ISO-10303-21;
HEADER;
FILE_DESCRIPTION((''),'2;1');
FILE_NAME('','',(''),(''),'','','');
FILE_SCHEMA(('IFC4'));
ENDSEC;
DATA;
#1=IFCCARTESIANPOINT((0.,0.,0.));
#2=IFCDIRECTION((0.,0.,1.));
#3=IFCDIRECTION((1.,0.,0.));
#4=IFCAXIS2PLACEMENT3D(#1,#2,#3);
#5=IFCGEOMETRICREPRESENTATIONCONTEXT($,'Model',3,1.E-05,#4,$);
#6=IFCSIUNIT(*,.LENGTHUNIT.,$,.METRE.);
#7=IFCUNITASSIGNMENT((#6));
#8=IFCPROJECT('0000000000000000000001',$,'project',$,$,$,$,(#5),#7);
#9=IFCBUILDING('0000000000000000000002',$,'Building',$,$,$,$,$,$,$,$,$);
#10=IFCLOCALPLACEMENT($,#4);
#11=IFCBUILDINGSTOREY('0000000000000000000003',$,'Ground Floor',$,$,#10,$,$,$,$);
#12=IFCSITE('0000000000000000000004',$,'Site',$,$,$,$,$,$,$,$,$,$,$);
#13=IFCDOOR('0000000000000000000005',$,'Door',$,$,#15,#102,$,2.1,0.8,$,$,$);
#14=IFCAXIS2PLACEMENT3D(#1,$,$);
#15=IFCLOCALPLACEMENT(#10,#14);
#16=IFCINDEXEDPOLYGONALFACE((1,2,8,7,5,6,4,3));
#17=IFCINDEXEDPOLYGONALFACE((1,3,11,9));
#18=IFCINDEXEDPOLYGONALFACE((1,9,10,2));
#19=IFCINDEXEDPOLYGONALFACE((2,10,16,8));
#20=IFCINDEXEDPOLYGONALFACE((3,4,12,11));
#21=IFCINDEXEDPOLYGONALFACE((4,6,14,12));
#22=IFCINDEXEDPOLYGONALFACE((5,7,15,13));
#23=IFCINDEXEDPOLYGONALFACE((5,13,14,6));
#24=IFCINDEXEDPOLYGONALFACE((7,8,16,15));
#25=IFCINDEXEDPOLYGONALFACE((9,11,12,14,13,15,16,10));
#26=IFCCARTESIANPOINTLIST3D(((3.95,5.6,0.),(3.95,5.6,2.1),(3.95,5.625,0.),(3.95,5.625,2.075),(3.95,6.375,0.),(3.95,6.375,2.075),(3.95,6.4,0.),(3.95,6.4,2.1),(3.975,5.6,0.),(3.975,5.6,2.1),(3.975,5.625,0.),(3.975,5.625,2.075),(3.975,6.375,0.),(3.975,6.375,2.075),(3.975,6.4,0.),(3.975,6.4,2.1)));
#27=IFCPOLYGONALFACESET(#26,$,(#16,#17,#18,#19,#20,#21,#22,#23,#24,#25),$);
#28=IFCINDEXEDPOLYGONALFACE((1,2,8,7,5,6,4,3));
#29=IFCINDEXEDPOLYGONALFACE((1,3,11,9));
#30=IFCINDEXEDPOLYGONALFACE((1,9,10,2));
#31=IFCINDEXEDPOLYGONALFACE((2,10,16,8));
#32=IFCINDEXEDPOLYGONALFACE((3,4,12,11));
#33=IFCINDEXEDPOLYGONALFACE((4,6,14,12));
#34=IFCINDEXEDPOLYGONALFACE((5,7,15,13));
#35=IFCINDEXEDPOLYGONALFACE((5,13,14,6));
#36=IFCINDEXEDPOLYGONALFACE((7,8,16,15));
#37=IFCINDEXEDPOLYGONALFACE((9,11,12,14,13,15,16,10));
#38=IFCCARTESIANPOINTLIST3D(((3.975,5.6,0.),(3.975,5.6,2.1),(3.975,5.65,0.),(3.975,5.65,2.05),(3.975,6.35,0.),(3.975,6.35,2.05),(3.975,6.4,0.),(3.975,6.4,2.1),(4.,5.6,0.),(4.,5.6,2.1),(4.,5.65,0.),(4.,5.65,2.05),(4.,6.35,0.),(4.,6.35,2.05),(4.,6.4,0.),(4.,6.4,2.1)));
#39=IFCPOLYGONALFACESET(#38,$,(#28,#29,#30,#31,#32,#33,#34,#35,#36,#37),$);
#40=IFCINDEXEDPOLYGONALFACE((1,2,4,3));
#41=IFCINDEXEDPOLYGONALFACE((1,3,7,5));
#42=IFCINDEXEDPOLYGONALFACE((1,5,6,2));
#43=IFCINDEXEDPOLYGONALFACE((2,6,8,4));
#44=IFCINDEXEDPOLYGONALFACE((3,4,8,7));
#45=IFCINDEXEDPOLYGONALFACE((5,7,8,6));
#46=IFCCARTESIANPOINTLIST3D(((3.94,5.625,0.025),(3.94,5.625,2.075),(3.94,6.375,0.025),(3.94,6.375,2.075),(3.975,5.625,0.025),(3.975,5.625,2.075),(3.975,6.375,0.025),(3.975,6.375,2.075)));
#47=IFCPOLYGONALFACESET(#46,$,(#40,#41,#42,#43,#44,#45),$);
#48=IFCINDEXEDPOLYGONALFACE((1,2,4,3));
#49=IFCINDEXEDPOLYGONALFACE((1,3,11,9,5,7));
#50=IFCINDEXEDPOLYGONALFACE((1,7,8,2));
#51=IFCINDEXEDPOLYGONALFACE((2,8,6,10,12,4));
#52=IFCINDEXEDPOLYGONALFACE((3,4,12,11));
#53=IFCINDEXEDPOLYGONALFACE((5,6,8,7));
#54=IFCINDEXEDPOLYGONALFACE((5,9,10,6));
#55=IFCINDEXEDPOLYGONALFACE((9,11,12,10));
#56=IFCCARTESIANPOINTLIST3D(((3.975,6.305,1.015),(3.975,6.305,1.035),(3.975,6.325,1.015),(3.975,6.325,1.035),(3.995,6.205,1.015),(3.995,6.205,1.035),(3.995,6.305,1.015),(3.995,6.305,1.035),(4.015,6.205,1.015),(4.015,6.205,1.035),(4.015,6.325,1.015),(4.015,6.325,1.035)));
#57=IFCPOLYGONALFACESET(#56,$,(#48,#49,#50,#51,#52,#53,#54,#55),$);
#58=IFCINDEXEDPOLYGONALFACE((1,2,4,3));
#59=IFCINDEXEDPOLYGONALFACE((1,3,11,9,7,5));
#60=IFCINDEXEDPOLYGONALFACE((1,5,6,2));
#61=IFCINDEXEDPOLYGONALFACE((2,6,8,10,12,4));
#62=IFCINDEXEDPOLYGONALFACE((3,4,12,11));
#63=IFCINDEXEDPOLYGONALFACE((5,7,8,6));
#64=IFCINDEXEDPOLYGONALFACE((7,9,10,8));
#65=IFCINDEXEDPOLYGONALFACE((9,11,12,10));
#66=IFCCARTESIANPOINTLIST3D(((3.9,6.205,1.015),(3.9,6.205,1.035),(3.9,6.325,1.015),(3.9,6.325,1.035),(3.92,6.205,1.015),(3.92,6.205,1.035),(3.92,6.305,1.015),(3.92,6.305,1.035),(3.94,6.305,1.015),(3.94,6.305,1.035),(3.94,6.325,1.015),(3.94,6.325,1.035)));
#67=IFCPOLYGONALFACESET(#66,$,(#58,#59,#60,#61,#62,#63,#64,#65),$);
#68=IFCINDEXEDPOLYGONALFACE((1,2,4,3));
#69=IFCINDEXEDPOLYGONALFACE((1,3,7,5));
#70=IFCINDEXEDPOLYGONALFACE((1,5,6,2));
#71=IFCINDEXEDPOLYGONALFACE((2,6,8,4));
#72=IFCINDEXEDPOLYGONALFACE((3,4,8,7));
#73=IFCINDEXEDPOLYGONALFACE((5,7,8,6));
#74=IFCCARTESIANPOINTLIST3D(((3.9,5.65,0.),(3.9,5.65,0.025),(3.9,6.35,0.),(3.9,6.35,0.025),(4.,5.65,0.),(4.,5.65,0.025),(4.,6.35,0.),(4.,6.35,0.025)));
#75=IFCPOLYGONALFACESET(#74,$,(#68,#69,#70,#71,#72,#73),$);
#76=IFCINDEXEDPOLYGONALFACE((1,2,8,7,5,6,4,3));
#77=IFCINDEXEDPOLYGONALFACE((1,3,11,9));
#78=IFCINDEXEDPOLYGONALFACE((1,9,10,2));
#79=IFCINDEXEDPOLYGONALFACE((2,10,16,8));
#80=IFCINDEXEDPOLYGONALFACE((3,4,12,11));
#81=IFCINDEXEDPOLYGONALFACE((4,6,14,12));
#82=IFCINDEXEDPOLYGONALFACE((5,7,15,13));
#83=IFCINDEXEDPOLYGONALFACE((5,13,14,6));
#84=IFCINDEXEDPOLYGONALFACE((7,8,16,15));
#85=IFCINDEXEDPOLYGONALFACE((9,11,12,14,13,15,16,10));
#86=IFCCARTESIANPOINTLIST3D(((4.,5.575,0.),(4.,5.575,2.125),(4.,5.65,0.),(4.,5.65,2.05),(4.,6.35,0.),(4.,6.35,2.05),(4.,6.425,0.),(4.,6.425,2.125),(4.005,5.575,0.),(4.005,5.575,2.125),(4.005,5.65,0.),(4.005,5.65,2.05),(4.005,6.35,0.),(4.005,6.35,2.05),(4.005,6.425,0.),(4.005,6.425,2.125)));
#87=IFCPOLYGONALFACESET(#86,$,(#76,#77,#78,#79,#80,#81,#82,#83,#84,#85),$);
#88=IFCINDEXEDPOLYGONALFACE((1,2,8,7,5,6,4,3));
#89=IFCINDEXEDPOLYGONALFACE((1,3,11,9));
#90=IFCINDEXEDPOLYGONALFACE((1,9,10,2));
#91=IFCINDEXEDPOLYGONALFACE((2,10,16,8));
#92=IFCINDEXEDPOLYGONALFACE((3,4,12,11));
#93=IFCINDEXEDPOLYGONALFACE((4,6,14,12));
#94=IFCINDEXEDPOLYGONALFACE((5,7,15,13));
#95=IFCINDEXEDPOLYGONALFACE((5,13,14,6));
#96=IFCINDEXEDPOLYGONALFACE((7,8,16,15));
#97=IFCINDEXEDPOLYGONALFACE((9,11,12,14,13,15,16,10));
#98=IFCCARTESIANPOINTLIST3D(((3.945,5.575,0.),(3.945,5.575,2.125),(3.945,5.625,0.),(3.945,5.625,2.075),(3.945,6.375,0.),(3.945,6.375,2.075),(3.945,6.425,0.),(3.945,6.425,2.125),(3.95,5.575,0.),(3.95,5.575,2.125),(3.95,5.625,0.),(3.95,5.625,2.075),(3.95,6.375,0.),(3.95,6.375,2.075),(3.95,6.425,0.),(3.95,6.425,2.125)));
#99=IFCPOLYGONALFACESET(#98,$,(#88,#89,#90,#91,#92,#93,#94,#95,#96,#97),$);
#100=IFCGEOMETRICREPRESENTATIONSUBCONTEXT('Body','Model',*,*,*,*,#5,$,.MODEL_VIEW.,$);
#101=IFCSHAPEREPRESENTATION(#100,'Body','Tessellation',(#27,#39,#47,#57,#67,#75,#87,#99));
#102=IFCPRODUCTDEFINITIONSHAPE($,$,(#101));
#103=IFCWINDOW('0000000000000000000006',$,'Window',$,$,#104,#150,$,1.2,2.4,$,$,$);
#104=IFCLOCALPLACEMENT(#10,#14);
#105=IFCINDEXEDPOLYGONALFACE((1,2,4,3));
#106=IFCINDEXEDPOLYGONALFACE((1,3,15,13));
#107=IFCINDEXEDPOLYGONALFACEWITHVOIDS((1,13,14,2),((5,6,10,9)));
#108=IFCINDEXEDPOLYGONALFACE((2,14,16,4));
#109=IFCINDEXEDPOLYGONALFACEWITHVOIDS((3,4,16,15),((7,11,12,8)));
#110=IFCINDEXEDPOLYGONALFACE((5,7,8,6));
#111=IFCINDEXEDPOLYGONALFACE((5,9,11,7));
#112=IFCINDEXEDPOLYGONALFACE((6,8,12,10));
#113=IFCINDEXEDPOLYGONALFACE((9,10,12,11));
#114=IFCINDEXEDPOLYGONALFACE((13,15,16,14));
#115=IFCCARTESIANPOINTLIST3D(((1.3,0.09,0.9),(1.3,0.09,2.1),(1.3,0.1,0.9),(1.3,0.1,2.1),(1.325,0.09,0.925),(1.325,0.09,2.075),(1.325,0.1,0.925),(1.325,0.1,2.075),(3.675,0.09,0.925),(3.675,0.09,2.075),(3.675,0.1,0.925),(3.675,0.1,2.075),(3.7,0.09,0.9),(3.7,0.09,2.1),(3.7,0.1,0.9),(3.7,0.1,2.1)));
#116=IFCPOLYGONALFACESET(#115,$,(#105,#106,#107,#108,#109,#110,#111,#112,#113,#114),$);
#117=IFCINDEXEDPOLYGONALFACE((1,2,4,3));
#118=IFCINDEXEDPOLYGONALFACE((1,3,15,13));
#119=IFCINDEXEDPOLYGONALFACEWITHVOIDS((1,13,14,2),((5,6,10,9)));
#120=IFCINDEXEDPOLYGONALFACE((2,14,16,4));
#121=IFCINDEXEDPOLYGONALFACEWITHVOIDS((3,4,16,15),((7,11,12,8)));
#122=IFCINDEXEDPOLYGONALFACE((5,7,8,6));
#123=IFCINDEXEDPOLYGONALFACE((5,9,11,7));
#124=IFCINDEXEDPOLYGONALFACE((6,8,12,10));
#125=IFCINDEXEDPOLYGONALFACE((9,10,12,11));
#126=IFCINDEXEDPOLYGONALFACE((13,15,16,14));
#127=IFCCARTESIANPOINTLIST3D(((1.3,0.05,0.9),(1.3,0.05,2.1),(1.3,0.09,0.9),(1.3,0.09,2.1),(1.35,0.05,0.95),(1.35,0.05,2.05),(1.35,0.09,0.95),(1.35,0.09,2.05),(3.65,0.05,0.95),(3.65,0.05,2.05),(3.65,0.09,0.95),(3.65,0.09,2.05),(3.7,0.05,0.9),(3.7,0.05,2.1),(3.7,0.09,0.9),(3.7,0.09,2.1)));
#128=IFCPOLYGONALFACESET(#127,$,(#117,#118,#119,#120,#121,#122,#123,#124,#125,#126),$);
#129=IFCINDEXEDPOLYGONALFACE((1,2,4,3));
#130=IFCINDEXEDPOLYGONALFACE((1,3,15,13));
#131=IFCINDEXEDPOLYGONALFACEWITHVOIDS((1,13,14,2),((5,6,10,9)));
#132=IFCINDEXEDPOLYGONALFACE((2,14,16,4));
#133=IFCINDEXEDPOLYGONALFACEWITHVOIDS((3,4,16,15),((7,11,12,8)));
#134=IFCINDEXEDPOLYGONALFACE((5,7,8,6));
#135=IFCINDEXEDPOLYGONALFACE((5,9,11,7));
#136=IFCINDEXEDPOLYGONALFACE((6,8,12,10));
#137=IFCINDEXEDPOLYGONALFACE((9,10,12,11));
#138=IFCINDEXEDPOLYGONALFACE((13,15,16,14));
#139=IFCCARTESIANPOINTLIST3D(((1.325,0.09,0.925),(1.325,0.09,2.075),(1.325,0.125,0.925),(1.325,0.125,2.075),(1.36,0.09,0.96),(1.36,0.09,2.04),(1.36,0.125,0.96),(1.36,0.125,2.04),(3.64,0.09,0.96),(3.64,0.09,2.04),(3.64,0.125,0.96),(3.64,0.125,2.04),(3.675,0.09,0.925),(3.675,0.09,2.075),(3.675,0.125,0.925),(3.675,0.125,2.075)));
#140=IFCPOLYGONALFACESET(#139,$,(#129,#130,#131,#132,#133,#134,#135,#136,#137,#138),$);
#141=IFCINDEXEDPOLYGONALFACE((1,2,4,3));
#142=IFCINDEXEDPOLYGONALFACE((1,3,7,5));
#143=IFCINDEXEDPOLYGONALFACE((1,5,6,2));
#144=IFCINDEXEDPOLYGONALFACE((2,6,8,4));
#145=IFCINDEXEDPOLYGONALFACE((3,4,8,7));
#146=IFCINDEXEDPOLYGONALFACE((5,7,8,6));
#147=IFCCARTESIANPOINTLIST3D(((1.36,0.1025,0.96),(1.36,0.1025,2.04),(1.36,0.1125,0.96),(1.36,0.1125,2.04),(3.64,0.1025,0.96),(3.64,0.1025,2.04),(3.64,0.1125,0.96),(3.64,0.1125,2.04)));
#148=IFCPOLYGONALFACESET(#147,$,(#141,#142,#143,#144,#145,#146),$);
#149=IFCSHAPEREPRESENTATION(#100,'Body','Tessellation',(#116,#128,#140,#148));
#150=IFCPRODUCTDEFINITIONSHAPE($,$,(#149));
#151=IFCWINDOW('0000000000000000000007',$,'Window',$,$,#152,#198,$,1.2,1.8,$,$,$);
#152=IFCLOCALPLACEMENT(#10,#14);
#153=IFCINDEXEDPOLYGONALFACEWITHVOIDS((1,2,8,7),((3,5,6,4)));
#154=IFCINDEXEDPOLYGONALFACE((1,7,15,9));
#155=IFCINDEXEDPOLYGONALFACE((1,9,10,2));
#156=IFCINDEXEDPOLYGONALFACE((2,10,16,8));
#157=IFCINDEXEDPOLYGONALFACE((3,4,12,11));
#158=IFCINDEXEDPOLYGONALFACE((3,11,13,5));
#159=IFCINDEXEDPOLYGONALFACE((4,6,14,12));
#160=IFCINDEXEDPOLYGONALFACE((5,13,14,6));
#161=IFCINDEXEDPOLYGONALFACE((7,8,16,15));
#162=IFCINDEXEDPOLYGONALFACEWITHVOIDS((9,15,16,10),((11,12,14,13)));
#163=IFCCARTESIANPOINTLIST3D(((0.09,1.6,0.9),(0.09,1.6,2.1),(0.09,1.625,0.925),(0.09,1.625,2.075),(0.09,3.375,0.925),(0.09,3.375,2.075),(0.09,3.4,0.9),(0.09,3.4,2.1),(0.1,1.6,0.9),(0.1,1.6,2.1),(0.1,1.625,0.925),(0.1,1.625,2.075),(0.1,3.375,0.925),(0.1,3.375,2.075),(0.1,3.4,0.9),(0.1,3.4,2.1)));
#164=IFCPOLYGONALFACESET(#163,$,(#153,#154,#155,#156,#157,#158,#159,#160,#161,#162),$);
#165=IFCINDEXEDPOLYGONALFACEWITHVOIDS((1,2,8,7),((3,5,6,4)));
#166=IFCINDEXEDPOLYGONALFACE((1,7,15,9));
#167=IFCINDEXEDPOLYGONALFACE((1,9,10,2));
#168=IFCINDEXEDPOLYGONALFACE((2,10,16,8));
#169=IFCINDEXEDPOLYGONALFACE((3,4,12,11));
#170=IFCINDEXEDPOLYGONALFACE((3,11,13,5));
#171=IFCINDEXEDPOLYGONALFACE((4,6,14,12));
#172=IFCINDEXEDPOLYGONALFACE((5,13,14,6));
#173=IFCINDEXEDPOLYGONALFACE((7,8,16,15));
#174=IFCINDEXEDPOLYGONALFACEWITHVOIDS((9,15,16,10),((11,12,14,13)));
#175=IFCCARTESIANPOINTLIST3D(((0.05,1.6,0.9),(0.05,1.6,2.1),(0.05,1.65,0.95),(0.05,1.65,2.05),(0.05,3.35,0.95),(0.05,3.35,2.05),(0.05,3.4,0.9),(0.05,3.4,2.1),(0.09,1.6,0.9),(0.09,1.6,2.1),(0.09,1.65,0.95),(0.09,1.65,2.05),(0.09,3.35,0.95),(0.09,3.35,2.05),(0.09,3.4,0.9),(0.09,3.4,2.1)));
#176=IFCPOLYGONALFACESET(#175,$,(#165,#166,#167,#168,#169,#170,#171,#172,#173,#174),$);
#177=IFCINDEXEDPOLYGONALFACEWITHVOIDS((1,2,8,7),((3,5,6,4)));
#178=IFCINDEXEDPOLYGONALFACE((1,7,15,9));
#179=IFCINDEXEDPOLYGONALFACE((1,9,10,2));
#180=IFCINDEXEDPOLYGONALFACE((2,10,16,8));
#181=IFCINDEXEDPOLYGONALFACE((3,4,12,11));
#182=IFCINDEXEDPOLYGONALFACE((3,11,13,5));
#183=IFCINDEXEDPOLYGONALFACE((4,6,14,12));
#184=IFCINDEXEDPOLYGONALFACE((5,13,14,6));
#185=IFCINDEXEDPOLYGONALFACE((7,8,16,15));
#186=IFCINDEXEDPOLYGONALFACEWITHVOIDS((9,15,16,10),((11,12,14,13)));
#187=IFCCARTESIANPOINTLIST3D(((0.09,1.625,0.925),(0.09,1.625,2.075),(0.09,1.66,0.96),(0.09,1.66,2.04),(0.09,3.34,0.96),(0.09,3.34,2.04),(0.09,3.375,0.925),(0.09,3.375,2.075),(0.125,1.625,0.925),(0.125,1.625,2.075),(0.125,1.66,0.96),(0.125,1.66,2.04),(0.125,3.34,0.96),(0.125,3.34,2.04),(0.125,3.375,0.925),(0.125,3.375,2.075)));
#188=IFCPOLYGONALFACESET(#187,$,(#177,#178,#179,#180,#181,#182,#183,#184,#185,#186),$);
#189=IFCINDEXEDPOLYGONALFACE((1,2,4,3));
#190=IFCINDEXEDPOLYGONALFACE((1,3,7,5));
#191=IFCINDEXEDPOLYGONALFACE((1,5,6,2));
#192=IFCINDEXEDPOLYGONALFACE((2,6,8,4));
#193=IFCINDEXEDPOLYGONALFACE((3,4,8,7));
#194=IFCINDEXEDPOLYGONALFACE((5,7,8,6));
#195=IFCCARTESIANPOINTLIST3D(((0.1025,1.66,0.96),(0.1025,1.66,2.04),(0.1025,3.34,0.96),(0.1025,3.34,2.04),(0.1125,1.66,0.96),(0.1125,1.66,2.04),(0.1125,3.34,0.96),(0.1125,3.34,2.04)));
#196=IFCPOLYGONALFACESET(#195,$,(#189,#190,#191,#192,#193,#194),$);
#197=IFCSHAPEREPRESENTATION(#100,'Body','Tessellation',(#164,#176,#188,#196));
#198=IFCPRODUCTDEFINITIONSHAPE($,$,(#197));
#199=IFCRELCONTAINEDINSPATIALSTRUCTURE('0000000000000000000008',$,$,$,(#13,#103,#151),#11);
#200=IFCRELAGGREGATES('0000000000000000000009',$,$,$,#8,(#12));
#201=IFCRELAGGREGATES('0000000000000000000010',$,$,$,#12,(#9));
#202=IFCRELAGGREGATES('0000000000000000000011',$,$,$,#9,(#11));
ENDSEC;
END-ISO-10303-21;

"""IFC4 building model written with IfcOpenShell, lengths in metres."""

from ifc_helpers import new_model, si_unit, frame, origin_with_axes, place, context, subcontext, project, spatial, line, indexed_curve, outline, extrude, element, save


model = new_model("IFC4")

# Units and contexts
model_context = context("Model", 3, precision=1e-05, world=origin_with_axes())
body_context = subcontext(model_context, "Body", "Model", "MODEL_VIEW")
ifc_project = project(units=[si_unit("LENGTHUNIT", "METRE")], contexts=[model_context])

# Site, building, storey
site = spatial("IfcSite", under=ifc_project, Name="Site")
building = spatial("IfcBuilding", under=site, Name="Building")
storey_placement = place(None, origin_with_axes())
storey = spatial("IfcBuildingStorey", under=building, at=storey_placement, Name="Ground Floor")

# Door
door_1_placement = place(storey_placement, frame((4.0, 5.6, 0.0), z_axis=(0.0, 0.0, 1.0), x_axis=(0.0, 1.0, 0.0)))
element("IfcDoor", 1, at=door_1_placement, inside=storey, Name="Door", OverallHeight=2.1, OverallWidth=0.8, context=body_context, shape_type="SweptSolid", body=[
    extrude(outline(indexed_curve([(0.0, 0.0), (0.0, 2.1), (0.8, 2.1), (0.8, 0.0), (0.775, 0.0), (0.775, 2.075), (0.025, 2.075), (0.025, 0.0)], segments=[line(1, 2, 3, 4, 5, 6, 7, 8, 1)])), frame((0.0, 0.025, 0.0), z_axis=(0.0, -1.0, 0.0), x_axis=(1.0, 0.0, 0.0)), (0.0, 0.0, -1.0), 0.025),
    extrude(outline(indexed_curve([(0.0, 0.0), (0.0, 2.1), (0.8, 2.1), (0.8, 0.0), (0.75, 0.0), (0.75, 2.05), (0.05, 2.05), (0.05, 0.0)], segments=[line(1, 2, 3, 4, 5, 6, 7, 8, 1)])), frame((0.0, 0.0, 0.0), z_axis=(0.0, -1.0, 0.0), x_axis=(1.0, 0.0, 0.0)), (0.0, 0.0, -1.0), 0.025),
    extrude(outline(indexed_curve([(0.0, 0.0), (0.75, 0.0), (0.75, 0.035), (0.0, 0.035)], segments=[line(1, 2, 3, 4, 1)])), frame((0.025, 0.025, 0.025), z_axis=(0.0, 0.0, 1.0), x_axis=(1.0, 0.0, 0.0)), (0.0, 0.0, 1.0), 2.05),
    extrude(outline(indexed_curve([(0.0, 0.0), (0.0, -0.04), (-0.12, -0.04), (-0.12, -0.02), (-0.02, -0.02), (-0.02, 0.0)], segments=[line(1, 2, 3, 4, 5, 6, 1)])), frame((0.725, 0.025, 1.015), z_axis=(0.0, 0.0, 1.0), x_axis=(1.0, 0.0, 0.0)), (0.0, 0.0, 1.0), 0.02),
    extrude(outline(indexed_curve([(0.0, 0.0), (0.0, 0.04), (-0.12, 0.04), (-0.12, 0.02), (-0.02, 0.02), (-0.02, 0.0)], segments=[line(1, 2, 3, 4, 5, 6, 1)])), frame((0.725, 0.06, 1.015), z_axis=(0.0, 0.0, 1.0), x_axis=(1.0, 0.0, 0.0)), (0.0, 0.0, 1.0), 0.02),
    extrude(outline(indexed_curve([(0.0, 0.0), (0.7, 0.0), (0.7, 0.1), (0.0, 0.1)], segments=[line(1, 2, 3, 4, 1)])), frame((0.05, 0.0, 0.0), z_axis=(0.0, 0.0, 1.0), x_axis=(1.0, 0.0, 0.0)), (0.0, 0.0, 1.0), 0.025),
    extrude(outline(indexed_curve([(0.0, 0.0), (0.0, 2.125), (0.85, 2.125), (0.85, 0.0), (0.775, 0.0), (0.775, 2.05), (0.075, 2.05), (0.075, 0.0)], segments=[line(1, 2, 3, 4, 5, 6, 7, 8, 1)])), frame((-0.025, -0.005, 0.0), z_axis=(0.0, -1.0, 0.0), x_axis=(1.0, 0.0, 0.0)), (0.0, 0.0, -1.0), 0.005),
    extrude(outline(indexed_curve([(0.0, 0.0), (0.0, 2.125), (0.85, 2.125), (0.85, 0.0), (0.8, 0.0), (0.8, 2.075), (0.05, 2.075), (0.05, 0.0)], segments=[line(1, 2, 3, 4, 5, 6, 7, 8, 1)])), frame((-0.025, 0.05, 0.0), z_axis=(0.0, -1.0, 0.0), x_axis=(1.0, 0.0, 0.0)), (0.0, 0.0, -1.0), 0.005),
])

# Windows
window_placement = place(storey_placement, frame((1.3, 0.0, 0.9), z_axis=(0.0, 0.0, 1.0), x_axis=(1.0, 0.0, 0.0)))
element("IfcWindow", 2, at=window_placement, inside=storey, Name="Window", OverallHeight=1.2, OverallWidth=2.4, context=body_context, shape_type="SweptSolid", body=[
    extrude(outline(indexed_curve([(0.0, 0.0), (2.4, 0.0), (2.4, 1.2), (0.0, 1.2)], segments=[line(1, 2, 3, 4, 1)]), holes=[indexed_curve([(0.025, 0.025), (2.375, 0.025), (2.375, 1.175), (0.025, 1.175)], segments=[line(1, 2, 3, 4, 1)])]), frame((0.0, 0.09, 0.0), z_axis=(0.0, -1.0, 0.0), x_axis=(1.0, 0.0, 0.0)), (0.0, 0.0, -1.0), 0.01),
    extrude(outline(indexed_curve([(0.0, 0.0), (2.4, 0.0), (2.4, 1.2), (0.0, 1.2)], segments=[line(1, 2, 3, 4, 1)]), holes=[indexed_curve([(0.05, 0.05), (2.35, 0.05), (2.35, 1.15), (0.05, 1.15)], segments=[line(1, 2, 3, 4, 1)])]), frame((0.0, 0.05, 0.0), z_axis=(0.0, -1.0, 0.0), x_axis=(1.0, 0.0, 0.0)), (0.0, 0.0, -1.0), 0.04),
    extrude(outline(indexed_curve([(0.0, 0.0), (2.35, 0.0), (2.35, 1.15), (0.0, 1.15)], segments=[line(1, 2, 3, 4, 1)]), holes=[indexed_curve([(0.035, 0.035), (2.315, 0.035), (2.315, 1.115), (0.035, 1.115)], segments=[line(1, 2, 3, 4, 1)])]), frame((0.025, 0.09, 0.025), z_axis=(0.0, -1.0, 0.0), x_axis=(1.0, 0.0, 0.0)), (0.0, 0.0, -1.0), 0.035),
    extrude(outline(indexed_curve([(0.035, 0.035), (2.315, 0.035), (2.315, 1.115), (0.035, 1.115)], segments=[line(1, 2, 3, 4, 1)])), frame((0.025, 0.1025, 0.025), z_axis=(0.0, -1.0, 0.0), x_axis=(1.0, 0.0, 0.0)), (0.0, 0.0, -1.0), 0.01),
])
for number, where, z_axis, x_axis, name in (
    (3, (0.0, 3.4, 0.9), (0.0, 0.0, 1.0), (0.0, -1.0, 0.0), "Window"),
):
    element("IfcWindow", number, at=place(storey_placement, frame(where, z_axis=z_axis, x_axis=x_axis)), inside=storey, Name=name, OverallHeight=1.2, OverallWidth=1.8, context=body_context, shape_type="SweptSolid", body=[
        extrude(outline(indexed_curve([(0.0, 0.0), (1.8, 0.0), (1.8, 1.2), (0.0, 1.2)], segments=[line(1, 2, 3, 4, 1)]), holes=[indexed_curve([(0.025, 0.025), (1.775, 0.025), (1.775, 1.175), (0.025, 1.175)], segments=[line(1, 2, 3, 4, 1)])]), frame((0.0, 0.09, 0.0), z_axis=(0.0, -1.0, 0.0), x_axis=(1.0, 0.0, 0.0)), (0.0, 0.0, -1.0), 0.01),
        extrude(outline(indexed_curve([(0.0, 0.0), (1.8, 0.0), (1.8, 1.2), (0.0, 1.2)], segments=[line(1, 2, 3, 4, 1)]), holes=[indexed_curve([(0.05, 0.05), (1.75, 0.05), (1.75, 1.15), (0.05, 1.15)], segments=[line(1, 2, 3, 4, 1)])]), frame((0.0, 0.05, 0.0), z_axis=(0.0, -1.0, 0.0), x_axis=(1.0, 0.0, 0.0)), (0.0, 0.0, -1.0), 0.04),
        extrude(outline(indexed_curve([(0.0, 0.0), (1.75, 0.0), (1.75, 1.15), (0.0, 1.15)], segments=[line(1, 2, 3, 4, 1)]), holes=[indexed_curve([(0.035, 0.035), (1.715, 0.035), (1.715, 1.115), (0.035, 1.115)], segments=[line(1, 2, 3, 4, 1)])]), frame((0.025, 0.09, 0.025), z_axis=(0.0, -1.0, 0.0), x_axis=(1.0, 0.0, 0.0)), (0.0, 0.0, -1.0), 0.035),
        extrude(outline(indexed_curve([(0.035, 0.035), (1.715, 0.035), (1.715, 1.115), (0.035, 1.115)], segments=[line(1, 2, 3, 4, 1)])), frame((0.025, 0.1025, 0.025), z_axis=(0.0, -1.0, 0.0), x_axis=(1.0, 0.0, 0.0)), (0.0, 0.0, -1.0), 0.01),
    ])

save(model, "model.ifc")
